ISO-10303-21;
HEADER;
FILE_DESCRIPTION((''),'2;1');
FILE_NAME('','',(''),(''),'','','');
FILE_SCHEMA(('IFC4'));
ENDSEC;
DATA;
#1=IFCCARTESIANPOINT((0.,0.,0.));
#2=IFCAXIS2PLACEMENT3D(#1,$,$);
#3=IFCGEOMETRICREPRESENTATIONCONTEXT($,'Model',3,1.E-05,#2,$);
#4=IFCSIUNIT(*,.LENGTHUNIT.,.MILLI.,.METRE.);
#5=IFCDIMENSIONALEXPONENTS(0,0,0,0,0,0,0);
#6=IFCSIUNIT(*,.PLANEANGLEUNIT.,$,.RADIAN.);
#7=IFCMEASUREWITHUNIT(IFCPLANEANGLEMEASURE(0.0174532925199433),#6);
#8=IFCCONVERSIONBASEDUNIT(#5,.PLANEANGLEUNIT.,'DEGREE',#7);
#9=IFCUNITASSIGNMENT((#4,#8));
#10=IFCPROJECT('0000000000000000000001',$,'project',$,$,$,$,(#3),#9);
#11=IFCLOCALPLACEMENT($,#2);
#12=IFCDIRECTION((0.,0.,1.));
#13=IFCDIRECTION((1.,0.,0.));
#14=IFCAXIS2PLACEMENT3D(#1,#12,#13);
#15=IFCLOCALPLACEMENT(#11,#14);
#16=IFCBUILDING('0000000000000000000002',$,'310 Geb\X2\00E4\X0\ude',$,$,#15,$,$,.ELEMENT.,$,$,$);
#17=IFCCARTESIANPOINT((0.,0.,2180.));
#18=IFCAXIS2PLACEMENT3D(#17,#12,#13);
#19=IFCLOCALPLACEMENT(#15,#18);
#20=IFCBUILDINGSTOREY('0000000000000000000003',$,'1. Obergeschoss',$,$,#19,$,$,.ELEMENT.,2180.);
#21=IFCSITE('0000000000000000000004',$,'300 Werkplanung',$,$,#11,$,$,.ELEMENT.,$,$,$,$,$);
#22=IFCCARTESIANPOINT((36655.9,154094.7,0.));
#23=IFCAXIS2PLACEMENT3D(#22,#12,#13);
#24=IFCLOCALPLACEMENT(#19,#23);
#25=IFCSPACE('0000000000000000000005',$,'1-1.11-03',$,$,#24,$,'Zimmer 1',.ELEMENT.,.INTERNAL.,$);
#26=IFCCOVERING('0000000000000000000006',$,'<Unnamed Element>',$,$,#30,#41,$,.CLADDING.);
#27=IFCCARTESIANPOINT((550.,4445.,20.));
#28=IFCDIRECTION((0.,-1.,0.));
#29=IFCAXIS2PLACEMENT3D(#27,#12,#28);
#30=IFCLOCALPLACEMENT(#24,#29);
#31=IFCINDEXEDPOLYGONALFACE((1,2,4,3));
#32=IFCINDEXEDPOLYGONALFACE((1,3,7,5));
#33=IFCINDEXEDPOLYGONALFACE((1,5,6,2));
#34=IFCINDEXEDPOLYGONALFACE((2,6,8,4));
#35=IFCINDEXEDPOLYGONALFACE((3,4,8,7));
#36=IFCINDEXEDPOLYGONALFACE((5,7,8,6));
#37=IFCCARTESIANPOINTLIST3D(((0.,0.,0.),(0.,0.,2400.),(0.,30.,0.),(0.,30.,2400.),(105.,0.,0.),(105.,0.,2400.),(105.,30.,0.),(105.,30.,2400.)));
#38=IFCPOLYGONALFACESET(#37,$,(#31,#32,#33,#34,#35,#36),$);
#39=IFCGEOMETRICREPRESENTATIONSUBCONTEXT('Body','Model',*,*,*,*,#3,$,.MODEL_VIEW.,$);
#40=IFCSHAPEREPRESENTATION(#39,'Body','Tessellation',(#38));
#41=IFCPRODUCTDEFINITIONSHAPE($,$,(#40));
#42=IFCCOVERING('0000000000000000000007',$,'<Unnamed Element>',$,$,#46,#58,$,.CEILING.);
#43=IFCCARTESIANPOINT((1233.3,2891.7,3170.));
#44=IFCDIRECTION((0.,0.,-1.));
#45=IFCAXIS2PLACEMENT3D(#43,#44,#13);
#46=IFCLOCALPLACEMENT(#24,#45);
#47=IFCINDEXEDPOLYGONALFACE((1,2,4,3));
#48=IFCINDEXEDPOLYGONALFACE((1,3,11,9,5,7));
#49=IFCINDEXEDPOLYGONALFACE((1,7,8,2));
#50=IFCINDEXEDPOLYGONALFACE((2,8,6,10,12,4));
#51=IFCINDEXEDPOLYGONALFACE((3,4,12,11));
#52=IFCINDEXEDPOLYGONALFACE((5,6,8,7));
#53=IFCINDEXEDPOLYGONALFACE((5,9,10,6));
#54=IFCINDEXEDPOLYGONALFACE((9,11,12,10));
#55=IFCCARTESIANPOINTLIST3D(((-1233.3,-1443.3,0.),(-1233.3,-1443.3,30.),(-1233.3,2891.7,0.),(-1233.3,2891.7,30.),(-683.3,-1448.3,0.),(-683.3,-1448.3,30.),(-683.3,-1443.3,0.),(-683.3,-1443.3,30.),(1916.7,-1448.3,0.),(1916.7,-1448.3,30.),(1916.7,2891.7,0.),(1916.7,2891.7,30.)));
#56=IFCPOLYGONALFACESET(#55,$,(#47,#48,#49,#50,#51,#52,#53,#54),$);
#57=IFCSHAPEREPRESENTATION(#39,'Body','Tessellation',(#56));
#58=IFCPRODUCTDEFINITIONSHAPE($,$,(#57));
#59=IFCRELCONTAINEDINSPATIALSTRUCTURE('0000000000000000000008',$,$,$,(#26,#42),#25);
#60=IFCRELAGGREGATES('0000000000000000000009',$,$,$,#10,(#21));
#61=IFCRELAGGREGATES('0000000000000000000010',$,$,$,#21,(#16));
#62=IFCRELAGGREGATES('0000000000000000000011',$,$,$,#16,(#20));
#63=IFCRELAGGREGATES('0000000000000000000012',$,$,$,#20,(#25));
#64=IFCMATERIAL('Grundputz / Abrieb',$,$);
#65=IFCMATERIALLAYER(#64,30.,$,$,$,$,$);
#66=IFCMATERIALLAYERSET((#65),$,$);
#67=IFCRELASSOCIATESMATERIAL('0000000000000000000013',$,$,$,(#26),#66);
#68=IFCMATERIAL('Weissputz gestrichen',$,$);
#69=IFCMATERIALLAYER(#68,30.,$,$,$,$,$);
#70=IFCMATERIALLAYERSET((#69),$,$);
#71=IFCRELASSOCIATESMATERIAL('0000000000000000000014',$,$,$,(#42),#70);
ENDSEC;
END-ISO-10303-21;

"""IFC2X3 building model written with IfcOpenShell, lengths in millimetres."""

from ifc_helpers import new_model, entity, si_unit, converted_unit, frame, frame_2d, origin, origin_with_axes, place, context, subcontext, project, spatial, polyline, rectangle, outline, extrude, material, layer, layer_set, layer_usage, element, save


model = new_model("IFC2X3")

# Units and contexts
model_context = context("Model", 3, precision=1e-05, world=origin())
body_context = subcontext(model_context, "Body", "Model", "MODEL_VIEW")
ifc_project = project(units=[si_unit("LENGTHUNIT", "METRE", prefix="MILLI"), converted_unit("PLANEANGLEUNIT", "DEGREE", entity("IfcPlaneAngleMeasure", 0.0174532925199433), si_unit("PLANEANGLEUNIT", "RADIAN"), dimensions=[0, 0, 0, 0, 0, 0, 0])], contexts=[model_context])

# Site, building, storey
site_placement = place(None, origin())
site = spatial("IfcSite", under=ifc_project, at=site_placement, Name="300 Werkplanung", CompositionType="ELEMENT")
building_placement = place(site_placement, origin_with_axes())
building = spatial("IfcBuilding", under=site, at=building_placement, Name="310 Gebäude", CompositionType="ELEMENT")
storey_placement = place(building_placement, frame((0.0, 0.0, 2180.0), z_axis=(0.0, 0.0, 1.0), x_axis=(1.0, 0.0, 0.0)))
storey = spatial("IfcBuildingStorey", under=building, at=storey_placement, Name="1. Obergeschoss", CompositionType="ELEMENT", Elevation=2180.0)

# Shared definitions
space_1_placement = place(storey_placement, frame((36655.9, 154094.7, 0.0), z_axis=(0.0, 0.0, 1.0), x_axis=(1.0, 0.0, 0.0)))
space_1 = spatial("IfcSpace", under=storey, at=space_1_placement, Name="1-1.11-03", LongName="Zimmer 1", CompositionType="ELEMENT", InteriorOrExteriorSpace="INTERNAL")

# Coverings
ifc_material_1 = material(Name="Grundputz / Abrieb")
ifc_layer_1 = layer(ifc_material_1, 30.0)
ifc_layer_set_1 = layer_set([ifc_layer_1])
ifc_layer_usage_1 = layer_usage(ifc_layer_set_1, "AXIS3", "POSITIVE", 0.0)
covering_1_placement = place(space_1_placement, frame((550.0, 4445.0, 20.0), z_axis=(0.0, 0.0, 1.0), x_axis=(0.0, -1.0, 0.0)))
element("IfcCovering", 1, at=covering_1_placement, inside=space_1, material=ifc_layer_usage_1, Name="<Unnamed Element>", PredefinedType="CLADDING", context=body_context, shape_type="SweptSolid", body=[
    extrude(rectangle(XDim=2400.0, YDim=105.0, at=frame_2d((-52.5, 1200.0), x_axis=(0.0, 1.0))), frame((105.0, 0.0, 2400.0), z_axis=(0.0, 1.0, 0.0), x_axis=(1.0, 0.0, 0.0)), (0.0, 0.0, 1.0), 30.0),
])
ifc_material_2 = material(Name="Weissputz gestrichen")
ifc_layer_2 = layer(ifc_material_2, 30.0)
ifc_layer_set_2 = layer_set([ifc_layer_2])
ifc_layer_usage_2 = layer_usage(ifc_layer_set_2, "AXIS3", "POSITIVE", 0.0)
covering_2_placement = place(space_1_placement, frame((1233.3, 2891.7, 3170.0), z_axis=(0.0, 0.0, -1.0), x_axis=(1.0, 0.0, 0.0)))
element("IfcCovering", 2, at=covering_2_placement, inside=space_1, material=ifc_layer_usage_2, Name="<Unnamed Element>", PredefinedType="CEILING", context=body_context, shape_type="SweptSolid", body=[
    extrude(outline(polyline([(-1233.3, 2891.7), (-1233.3, -1443.3), (-683.3, -1443.3), (-683.3, -1448.3), (1916.7, -1448.3), (1916.7, 2891.7), (-1233.3, 2891.7)])), origin_with_axes(), (0.0, 0.0, 1.0), 30.0),
])

save(model, "model.ifc")
